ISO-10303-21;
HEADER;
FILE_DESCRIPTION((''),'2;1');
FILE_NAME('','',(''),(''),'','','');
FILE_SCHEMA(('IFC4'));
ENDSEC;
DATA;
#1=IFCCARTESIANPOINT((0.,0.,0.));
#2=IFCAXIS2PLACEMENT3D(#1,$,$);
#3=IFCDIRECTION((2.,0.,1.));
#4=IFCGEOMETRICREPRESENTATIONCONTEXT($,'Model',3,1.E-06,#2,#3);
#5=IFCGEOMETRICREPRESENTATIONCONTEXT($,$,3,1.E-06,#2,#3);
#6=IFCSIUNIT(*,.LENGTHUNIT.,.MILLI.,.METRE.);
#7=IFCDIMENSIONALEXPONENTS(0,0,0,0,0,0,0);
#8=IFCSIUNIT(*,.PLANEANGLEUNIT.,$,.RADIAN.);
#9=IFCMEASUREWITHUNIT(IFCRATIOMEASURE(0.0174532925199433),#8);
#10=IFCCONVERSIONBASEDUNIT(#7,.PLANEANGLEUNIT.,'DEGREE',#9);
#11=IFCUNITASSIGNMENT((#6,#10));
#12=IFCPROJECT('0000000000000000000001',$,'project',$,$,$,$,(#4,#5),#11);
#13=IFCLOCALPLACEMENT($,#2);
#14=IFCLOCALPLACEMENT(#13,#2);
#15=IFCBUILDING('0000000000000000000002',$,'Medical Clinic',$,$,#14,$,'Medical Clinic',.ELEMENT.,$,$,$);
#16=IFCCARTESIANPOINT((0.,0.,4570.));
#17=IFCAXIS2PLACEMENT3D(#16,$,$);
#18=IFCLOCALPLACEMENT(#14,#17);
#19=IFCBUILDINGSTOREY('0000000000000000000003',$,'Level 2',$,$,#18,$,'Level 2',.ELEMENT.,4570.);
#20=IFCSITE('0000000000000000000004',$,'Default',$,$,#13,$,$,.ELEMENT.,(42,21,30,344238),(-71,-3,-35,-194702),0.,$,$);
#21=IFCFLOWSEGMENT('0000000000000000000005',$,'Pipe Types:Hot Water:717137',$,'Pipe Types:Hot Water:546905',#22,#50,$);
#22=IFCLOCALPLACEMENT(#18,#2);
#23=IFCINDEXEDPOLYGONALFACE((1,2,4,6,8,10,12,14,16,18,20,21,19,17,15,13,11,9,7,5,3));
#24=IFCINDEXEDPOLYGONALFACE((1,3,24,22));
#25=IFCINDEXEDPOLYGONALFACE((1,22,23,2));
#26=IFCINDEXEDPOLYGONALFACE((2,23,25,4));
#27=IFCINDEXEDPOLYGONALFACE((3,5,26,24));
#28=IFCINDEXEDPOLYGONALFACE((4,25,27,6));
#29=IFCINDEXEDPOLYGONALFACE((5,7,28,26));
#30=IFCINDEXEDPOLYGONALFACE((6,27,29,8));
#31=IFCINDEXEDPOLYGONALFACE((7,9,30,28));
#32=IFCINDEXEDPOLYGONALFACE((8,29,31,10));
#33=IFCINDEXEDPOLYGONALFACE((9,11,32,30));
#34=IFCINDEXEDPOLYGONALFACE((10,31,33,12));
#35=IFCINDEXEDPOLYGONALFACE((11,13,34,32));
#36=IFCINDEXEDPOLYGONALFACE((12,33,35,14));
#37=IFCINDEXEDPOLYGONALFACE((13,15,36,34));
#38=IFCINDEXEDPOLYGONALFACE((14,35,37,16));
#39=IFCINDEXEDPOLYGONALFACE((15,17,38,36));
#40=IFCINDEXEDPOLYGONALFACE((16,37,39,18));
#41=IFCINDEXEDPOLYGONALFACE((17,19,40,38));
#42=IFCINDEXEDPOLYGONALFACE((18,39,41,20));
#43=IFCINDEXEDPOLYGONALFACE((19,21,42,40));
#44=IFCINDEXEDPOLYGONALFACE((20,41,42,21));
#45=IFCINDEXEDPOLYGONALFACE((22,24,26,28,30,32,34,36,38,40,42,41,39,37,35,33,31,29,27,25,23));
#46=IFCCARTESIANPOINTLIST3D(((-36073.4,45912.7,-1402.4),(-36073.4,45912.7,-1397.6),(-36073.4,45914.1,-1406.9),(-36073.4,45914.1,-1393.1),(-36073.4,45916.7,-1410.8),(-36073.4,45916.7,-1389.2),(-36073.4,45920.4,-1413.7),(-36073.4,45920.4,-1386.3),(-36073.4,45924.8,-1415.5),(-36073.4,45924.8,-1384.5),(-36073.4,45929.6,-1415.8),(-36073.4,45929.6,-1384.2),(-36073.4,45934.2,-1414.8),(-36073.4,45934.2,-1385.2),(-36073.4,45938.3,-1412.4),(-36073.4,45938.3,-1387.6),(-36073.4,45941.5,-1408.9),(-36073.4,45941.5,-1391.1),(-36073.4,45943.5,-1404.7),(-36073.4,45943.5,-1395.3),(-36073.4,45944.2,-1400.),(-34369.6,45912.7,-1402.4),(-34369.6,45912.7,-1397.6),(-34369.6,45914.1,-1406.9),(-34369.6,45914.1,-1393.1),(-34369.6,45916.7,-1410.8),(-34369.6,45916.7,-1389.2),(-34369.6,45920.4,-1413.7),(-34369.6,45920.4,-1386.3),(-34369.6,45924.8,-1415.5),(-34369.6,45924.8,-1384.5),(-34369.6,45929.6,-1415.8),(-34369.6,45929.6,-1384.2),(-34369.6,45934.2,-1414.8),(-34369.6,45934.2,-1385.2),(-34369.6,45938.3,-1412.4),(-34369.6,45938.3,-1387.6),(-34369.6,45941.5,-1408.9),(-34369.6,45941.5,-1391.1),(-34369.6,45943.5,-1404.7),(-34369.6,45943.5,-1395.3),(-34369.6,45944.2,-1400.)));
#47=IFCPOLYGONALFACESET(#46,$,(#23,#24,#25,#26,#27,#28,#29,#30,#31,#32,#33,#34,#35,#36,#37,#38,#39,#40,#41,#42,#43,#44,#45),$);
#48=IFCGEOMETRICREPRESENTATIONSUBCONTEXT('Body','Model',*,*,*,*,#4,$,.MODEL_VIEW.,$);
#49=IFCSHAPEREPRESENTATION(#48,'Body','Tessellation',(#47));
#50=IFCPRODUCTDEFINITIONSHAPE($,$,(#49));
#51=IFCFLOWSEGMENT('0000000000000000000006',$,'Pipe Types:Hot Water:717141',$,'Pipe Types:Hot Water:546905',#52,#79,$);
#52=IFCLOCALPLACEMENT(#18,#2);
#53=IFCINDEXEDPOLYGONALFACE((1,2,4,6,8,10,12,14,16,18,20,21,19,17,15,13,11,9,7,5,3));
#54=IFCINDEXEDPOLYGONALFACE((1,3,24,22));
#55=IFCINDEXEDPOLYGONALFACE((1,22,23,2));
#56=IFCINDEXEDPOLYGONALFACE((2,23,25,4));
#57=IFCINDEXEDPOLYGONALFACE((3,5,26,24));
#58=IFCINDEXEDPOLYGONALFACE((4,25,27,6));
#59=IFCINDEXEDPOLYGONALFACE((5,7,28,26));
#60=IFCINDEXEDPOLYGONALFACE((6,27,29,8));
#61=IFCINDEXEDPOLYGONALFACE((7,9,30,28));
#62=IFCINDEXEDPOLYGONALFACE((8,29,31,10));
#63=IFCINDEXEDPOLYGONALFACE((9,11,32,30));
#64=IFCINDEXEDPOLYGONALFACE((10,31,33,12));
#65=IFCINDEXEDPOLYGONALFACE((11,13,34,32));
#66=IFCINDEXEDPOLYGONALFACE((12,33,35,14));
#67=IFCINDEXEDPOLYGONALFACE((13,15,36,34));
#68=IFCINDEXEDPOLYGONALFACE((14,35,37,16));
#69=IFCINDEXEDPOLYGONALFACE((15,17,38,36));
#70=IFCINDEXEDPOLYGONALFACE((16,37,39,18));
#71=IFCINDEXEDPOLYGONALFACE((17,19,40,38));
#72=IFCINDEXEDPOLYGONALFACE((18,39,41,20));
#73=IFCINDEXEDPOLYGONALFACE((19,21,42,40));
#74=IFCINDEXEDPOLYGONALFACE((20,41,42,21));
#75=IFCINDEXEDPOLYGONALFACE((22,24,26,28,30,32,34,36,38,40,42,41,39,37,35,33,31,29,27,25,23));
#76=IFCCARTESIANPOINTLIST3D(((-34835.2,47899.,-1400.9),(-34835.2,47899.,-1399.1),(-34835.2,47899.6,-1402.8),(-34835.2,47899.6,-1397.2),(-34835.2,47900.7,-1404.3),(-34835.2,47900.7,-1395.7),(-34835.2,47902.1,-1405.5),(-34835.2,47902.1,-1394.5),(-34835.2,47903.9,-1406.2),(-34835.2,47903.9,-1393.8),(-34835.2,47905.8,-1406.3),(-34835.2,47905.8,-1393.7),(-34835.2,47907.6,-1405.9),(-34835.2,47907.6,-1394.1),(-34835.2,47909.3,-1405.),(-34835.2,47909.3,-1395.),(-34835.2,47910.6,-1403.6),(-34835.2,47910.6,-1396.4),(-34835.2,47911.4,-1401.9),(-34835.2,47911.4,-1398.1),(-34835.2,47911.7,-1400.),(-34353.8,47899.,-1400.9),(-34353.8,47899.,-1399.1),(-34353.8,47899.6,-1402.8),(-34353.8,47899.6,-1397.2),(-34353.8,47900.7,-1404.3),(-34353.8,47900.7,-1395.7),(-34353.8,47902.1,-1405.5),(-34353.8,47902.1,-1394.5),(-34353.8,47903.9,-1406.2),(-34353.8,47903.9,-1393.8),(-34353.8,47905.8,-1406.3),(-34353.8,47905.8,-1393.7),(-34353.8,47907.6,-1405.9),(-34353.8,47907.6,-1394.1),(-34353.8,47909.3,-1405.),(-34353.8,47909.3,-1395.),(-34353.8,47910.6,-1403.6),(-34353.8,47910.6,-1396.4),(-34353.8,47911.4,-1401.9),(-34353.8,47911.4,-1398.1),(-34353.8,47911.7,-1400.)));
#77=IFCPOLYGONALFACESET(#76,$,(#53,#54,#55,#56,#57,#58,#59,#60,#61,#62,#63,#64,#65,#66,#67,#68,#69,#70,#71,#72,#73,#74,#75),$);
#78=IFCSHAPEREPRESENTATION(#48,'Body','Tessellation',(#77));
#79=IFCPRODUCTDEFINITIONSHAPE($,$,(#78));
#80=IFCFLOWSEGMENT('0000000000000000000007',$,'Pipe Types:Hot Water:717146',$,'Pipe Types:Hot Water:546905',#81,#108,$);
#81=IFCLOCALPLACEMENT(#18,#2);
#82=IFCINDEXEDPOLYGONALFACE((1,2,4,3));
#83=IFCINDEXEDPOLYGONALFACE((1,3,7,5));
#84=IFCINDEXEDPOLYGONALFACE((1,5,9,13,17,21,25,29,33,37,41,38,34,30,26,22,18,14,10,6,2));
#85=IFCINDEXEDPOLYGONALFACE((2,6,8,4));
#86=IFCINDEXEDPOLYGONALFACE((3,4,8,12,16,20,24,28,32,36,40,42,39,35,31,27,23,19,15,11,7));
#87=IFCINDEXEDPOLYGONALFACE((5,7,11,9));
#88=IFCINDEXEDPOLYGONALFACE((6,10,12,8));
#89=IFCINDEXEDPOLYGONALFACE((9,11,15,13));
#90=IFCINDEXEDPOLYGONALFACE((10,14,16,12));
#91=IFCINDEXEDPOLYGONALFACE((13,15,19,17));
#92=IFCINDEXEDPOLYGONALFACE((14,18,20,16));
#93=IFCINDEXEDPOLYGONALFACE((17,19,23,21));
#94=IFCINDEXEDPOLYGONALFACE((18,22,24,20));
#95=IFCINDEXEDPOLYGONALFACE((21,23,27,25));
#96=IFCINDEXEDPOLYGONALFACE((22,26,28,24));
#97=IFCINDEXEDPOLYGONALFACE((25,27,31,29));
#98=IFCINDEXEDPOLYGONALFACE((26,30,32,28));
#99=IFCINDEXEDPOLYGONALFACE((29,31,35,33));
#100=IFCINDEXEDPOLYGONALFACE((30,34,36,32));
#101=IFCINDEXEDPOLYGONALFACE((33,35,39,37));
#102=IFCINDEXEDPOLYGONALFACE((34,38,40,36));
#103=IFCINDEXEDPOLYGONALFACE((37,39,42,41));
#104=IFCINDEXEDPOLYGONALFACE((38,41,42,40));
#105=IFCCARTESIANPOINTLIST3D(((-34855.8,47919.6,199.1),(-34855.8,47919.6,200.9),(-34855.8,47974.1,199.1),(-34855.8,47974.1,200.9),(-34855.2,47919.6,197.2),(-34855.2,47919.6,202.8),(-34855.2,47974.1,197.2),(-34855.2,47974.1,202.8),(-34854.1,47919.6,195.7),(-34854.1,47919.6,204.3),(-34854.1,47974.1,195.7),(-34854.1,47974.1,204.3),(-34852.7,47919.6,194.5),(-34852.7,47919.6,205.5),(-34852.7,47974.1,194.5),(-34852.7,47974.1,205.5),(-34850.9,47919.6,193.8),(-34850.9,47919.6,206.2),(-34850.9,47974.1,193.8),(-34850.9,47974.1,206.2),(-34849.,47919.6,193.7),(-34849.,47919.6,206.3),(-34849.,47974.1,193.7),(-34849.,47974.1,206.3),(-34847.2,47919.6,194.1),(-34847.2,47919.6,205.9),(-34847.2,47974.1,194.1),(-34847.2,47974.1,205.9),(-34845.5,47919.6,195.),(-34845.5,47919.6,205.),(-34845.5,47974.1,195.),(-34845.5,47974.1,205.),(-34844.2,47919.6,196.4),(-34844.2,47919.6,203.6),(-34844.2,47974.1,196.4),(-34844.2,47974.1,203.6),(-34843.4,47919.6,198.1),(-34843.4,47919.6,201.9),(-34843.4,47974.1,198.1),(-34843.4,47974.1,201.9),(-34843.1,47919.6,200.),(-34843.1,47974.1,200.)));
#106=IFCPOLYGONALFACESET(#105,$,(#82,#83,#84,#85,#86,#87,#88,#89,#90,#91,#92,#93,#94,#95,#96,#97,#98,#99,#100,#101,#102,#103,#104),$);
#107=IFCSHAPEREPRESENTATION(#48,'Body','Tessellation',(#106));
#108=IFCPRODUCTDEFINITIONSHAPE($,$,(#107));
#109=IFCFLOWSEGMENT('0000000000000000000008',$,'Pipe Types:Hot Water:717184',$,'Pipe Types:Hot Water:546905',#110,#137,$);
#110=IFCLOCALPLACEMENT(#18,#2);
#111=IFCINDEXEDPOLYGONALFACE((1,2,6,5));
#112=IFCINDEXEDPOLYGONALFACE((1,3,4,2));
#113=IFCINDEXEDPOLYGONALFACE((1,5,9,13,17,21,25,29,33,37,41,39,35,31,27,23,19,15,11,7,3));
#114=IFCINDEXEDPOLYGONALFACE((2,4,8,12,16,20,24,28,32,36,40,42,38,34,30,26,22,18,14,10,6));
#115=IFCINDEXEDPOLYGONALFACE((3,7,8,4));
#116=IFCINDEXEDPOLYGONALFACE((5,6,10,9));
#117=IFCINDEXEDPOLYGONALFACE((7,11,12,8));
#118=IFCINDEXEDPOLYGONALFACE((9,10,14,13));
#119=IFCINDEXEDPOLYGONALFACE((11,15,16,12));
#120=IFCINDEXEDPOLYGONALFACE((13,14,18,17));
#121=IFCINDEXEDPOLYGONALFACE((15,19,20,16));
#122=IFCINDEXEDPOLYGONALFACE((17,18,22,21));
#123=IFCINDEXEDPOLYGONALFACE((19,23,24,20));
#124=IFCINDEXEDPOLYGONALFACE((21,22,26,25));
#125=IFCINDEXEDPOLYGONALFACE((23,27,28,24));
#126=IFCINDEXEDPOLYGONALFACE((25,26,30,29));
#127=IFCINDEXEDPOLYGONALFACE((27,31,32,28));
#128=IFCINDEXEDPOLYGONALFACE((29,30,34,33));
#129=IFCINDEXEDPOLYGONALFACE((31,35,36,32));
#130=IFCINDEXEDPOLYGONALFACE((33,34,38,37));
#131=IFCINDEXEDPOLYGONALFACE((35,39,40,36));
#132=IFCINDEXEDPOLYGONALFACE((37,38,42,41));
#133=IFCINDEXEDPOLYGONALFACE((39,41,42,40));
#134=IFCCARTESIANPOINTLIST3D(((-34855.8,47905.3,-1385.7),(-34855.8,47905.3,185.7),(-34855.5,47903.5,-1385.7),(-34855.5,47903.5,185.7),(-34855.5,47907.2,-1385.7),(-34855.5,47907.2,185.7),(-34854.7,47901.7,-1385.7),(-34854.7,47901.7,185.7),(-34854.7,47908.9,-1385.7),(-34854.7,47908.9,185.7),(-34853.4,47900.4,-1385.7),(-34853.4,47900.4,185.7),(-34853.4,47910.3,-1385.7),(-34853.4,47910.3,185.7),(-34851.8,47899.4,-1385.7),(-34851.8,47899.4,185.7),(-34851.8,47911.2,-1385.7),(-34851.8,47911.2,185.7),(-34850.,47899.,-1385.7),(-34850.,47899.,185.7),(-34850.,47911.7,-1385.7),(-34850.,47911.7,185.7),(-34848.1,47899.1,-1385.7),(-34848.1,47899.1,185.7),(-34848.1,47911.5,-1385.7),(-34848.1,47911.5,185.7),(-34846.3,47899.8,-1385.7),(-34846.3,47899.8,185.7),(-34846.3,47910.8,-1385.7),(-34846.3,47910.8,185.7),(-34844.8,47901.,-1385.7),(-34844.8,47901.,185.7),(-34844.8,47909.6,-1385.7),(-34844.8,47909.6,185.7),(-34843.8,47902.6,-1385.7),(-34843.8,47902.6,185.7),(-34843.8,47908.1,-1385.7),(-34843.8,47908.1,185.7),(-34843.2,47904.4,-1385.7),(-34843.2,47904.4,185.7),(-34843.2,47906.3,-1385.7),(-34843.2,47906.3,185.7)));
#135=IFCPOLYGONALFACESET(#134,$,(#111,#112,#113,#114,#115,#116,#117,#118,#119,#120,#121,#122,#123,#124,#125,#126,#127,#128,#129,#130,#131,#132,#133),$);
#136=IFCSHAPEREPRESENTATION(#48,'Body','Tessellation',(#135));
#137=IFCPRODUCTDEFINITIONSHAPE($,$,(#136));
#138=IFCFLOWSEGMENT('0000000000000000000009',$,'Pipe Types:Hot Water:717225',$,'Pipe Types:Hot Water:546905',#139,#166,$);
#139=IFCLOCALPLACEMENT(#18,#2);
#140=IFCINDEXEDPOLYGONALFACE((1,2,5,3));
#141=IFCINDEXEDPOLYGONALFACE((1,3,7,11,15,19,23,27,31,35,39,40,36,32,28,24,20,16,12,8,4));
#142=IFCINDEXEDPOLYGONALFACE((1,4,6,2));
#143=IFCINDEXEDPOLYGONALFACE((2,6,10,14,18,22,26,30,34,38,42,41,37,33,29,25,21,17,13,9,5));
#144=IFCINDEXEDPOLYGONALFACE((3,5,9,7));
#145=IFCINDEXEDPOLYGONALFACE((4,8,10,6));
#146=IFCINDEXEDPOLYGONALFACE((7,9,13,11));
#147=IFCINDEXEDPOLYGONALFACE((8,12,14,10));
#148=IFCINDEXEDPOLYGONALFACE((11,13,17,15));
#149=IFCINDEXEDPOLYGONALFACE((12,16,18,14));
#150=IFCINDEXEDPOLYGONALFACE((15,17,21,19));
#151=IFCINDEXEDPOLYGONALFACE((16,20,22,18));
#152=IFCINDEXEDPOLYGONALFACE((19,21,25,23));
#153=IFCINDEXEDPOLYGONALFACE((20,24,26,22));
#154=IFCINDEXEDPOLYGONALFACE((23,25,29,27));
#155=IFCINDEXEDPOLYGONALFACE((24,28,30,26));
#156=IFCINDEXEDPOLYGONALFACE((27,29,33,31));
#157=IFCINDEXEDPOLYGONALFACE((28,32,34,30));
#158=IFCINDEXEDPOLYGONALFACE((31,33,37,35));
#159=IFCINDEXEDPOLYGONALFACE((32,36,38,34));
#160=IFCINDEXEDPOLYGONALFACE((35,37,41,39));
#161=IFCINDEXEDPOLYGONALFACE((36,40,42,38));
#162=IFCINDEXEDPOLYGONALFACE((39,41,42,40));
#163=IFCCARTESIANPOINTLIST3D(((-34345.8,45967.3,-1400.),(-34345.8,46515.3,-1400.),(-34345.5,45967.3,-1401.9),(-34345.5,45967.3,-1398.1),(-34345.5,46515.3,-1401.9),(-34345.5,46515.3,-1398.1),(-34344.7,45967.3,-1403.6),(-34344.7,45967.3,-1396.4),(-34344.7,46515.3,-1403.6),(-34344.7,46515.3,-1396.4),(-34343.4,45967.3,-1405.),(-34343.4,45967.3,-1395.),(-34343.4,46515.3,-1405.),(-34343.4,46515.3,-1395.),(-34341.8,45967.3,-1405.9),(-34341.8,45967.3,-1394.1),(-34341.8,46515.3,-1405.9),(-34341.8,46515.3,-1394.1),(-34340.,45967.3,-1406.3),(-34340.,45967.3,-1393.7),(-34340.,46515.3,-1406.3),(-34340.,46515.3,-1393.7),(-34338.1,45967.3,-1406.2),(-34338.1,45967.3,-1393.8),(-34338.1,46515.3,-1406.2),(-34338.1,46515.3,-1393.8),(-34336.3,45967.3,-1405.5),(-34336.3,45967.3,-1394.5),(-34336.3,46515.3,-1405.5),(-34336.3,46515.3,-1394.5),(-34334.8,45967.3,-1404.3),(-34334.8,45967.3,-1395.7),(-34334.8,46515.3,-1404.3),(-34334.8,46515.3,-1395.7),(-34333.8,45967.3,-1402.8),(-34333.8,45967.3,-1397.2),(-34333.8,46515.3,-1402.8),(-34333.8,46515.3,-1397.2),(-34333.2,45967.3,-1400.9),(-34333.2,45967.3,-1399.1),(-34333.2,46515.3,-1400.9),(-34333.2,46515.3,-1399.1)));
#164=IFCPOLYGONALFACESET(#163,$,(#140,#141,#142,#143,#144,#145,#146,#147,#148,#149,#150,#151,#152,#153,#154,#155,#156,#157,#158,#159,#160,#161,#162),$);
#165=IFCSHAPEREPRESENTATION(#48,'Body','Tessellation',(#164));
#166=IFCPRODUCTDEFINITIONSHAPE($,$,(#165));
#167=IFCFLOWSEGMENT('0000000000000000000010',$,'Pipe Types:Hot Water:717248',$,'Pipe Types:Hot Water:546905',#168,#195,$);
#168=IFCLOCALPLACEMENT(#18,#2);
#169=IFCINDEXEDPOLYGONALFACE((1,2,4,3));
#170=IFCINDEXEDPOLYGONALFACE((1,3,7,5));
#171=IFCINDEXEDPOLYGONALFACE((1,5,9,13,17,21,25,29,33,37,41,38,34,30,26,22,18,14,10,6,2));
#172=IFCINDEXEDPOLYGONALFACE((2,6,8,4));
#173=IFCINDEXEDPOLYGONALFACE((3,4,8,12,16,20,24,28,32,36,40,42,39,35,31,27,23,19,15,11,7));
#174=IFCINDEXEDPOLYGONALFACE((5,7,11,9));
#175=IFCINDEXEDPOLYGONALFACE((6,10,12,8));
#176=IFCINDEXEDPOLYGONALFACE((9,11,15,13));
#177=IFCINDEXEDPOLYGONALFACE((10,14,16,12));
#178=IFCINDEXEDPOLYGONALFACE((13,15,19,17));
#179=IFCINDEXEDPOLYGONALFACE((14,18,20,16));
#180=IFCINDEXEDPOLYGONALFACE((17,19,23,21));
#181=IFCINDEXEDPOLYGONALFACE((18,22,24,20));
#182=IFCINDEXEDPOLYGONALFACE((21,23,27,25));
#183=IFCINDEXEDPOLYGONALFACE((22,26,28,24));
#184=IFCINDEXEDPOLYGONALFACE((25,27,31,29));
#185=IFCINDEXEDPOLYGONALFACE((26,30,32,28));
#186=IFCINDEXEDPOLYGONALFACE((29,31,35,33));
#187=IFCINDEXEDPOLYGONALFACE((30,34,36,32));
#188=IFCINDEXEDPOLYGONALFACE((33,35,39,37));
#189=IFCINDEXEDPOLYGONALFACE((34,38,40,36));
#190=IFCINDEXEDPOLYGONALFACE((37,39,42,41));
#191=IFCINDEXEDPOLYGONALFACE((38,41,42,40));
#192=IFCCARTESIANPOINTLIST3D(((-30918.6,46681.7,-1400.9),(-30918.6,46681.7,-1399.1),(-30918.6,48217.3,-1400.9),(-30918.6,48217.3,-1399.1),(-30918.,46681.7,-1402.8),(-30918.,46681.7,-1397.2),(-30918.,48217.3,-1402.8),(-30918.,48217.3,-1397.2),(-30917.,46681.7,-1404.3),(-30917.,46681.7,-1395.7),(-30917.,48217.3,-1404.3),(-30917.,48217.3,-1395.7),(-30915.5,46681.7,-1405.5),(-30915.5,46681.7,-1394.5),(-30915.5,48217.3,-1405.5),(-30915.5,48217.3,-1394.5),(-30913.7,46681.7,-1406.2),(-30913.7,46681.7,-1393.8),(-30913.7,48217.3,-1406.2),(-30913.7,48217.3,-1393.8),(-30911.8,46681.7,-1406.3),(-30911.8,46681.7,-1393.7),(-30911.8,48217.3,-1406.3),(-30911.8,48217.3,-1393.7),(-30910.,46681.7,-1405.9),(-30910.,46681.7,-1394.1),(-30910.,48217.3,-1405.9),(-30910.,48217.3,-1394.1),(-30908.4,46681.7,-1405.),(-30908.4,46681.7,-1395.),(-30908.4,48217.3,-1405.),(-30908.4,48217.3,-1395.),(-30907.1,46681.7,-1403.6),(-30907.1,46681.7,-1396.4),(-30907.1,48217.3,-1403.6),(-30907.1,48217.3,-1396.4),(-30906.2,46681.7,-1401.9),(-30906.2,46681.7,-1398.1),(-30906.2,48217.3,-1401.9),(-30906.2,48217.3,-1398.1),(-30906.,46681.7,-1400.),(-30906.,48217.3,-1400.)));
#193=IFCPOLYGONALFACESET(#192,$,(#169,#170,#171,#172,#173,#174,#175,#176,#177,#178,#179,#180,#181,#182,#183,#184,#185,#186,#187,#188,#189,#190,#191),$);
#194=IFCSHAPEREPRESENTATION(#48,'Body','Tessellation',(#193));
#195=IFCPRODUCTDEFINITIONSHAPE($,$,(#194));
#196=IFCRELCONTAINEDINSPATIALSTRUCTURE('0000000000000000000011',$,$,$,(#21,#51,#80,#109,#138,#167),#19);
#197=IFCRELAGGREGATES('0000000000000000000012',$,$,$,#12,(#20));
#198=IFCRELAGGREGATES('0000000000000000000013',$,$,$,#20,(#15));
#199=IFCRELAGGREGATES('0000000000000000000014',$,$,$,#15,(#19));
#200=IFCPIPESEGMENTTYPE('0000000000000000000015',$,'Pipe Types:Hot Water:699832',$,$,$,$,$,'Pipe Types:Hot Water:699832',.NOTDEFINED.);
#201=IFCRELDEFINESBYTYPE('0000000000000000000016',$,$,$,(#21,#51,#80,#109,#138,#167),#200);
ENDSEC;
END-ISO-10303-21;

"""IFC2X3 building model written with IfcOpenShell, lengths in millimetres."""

from ifc_helpers import new_model, entity, si_unit, converted_unit, direction, frame, frame_2d, origin, origin_2d_with_axis, place, context, subcontext, project, spatial, circle, extrude, type_object, element, save


model = new_model("IFC2X3")

# Units and contexts
model_context = context("Model", 3, precision=1e-06, world=origin(), true_north=direction((2.0, 0.0, 1.0)))
context_of_model = context(None, 3, precision=1e-06, world=origin(), true_north=direction((2.0, 0.0, 1.0)))
body_context = subcontext(model_context, "Body", "Model", "MODEL_VIEW")
ifc_project = project(units=[si_unit("LENGTHUNIT", "METRE", prefix="MILLI"), converted_unit("PLANEANGLEUNIT", "DEGREE", entity("IfcRatioMeasure", 0.0174532925199433), si_unit("PLANEANGLEUNIT", "RADIAN"), dimensions=[0, 0, 0, 0, 0, 0, 0])], contexts=[model_context, context_of_model])

# Site, building, storey
site_placement = place(None, origin())
site = spatial("IfcSite", under=ifc_project, at=site_placement, Name="Default", CompositionType="ELEMENT", RefLatitude=(42, 21, 30, 344238), RefLongitude=(-71, -3, -35, -194702), RefElevation=0.0)
building_placement = place(site_placement, origin())
building = spatial("IfcBuilding", under=site, at=building_placement, Name="Medical Clinic", LongName="Medical Clinic", CompositionType="ELEMENT")
storey_placement = place(building_placement, frame((0.0, 0.0, 4570.0)))
storey = spatial("IfcBuildingStorey", under=building, at=storey_placement, Name="Level 2", LongName="Level 2", CompositionType="ELEMENT", Elevation=4570.0)

# Flow segments
pipe_segment_type = type_object("IfcPipeSegmentType", Name="Pipe Types:Hot Water:699832", ElementType="Pipe Types:Hot Water:699832", PredefinedType="NOTDEFINED")
flow_segment_1_placement = place(storey_placement, origin())
element("IfcFlowSegment", 1, at=flow_segment_1_placement, inside=storey, type_object=pipe_segment_type, Name="Pipe Types:Hot Water:717137", ObjectType="Pipe Types:Hot Water:546905", context=body_context, shape_type="SweptSolid", body=[
    extrude(circle(Radius=15.9, at=frame_2d((0.0, 0.0), x_axis=(1.0, 0.0))), frame((-36073.4, 45928.4, -1400.0), z_axis=(1.0, 0.0, 0.0), x_axis=(0.0, 1.0, 0.0)), (0.0, 0.0, 1.0), 1703.8),
])
flow_segment_2_placement = place(storey_placement, origin())
element("IfcFlowSegment", 2, at=flow_segment_2_placement, inside=storey, type_object=pipe_segment_type, Name="Pipe Types:Hot Water:717141", ObjectType="Pipe Types:Hot Water:546905", context=body_context, shape_type="SweptSolid", body=[
    extrude(circle(Radius=6.3, at=frame_2d((0.0, 0.0), x_axis=(1.0, 0.0))), frame((-34835.2, 47905.3, -1400.0), z_axis=(1.0, 0.0, 0.0), x_axis=(0.0, 1.0, 0.0)), (0.0, 0.0, 1.0), 481.4),
])
flow_segment_3_placement = place(storey_placement, origin())
element("IfcFlowSegment", 3, at=flow_segment_3_placement, inside=storey, type_object=pipe_segment_type, Name="Pipe Types:Hot Water:717146", ObjectType="Pipe Types:Hot Water:546905", context=body_context, shape_type="SweptSolid", body=[
    extrude(circle(Radius=6.3, at=origin_2d_with_axis()), frame((-34849.5, 47919.6, 200.0), z_axis=(0.0, 1.0, 0.0), x_axis=(1.0, 0.0, 0.0)), (0.0, 0.0, 1.0), 54.5),
])
flow_segment_4_placement = place(storey_placement, origin())
element("IfcFlowSegment", 4, at=flow_segment_4_placement, inside=storey, type_object=pipe_segment_type, Name="Pipe Types:Hot Water:717184", ObjectType="Pipe Types:Hot Water:546905", context=body_context, shape_type="SweptSolid", body=[
    extrude(circle(Radius=6.3, at=origin_2d_with_axis()), frame((-34849.5, 47905.3, -1385.7), z_axis=(0.0, 0.0, 1.0), x_axis=(-1.0, 0.0, 0.0)), (0.0, 0.0, 1.0), 1571.4),
])
flow_segment_5_placement = place(storey_placement, origin())
element("IfcFlowSegment", 5, at=flow_segment_5_placement, inside=storey, type_object=pipe_segment_type, Name="Pipe Types:Hot Water:717225", ObjectType="Pipe Types:Hot Water:546905", context=body_context, shape_type="SweptSolid", body=[
    extrude(circle(Radius=6.3, at=origin_2d_with_axis()), frame((-34339.5, 45967.3, -1400.0), z_axis=(0.0, 1.0, 0.0), x_axis=(-1.0, 0.0, 0.0)), (0.0, 0.0, 1.0), 548.0),
])
flow_segment_6_placement = place(storey_placement, origin())
element("IfcFlowSegment", 6, at=flow_segment_6_placement, inside=storey, type_object=pipe_segment_type, Name="Pipe Types:Hot Water:717248", ObjectType="Pipe Types:Hot Water:546905", context=body_context, shape_type="SweptSolid", body=[
    extrude(circle(Radius=6.3, at=origin_2d_with_axis()), frame((-30912.3, 46681.7, -1400.0), z_axis=(0.0, 1.0, 0.0), x_axis=(1.0, 0.0, 0.0)), (0.0, 0.0, 1.0), 1535.6),
])

save(model, "model.ifc")
